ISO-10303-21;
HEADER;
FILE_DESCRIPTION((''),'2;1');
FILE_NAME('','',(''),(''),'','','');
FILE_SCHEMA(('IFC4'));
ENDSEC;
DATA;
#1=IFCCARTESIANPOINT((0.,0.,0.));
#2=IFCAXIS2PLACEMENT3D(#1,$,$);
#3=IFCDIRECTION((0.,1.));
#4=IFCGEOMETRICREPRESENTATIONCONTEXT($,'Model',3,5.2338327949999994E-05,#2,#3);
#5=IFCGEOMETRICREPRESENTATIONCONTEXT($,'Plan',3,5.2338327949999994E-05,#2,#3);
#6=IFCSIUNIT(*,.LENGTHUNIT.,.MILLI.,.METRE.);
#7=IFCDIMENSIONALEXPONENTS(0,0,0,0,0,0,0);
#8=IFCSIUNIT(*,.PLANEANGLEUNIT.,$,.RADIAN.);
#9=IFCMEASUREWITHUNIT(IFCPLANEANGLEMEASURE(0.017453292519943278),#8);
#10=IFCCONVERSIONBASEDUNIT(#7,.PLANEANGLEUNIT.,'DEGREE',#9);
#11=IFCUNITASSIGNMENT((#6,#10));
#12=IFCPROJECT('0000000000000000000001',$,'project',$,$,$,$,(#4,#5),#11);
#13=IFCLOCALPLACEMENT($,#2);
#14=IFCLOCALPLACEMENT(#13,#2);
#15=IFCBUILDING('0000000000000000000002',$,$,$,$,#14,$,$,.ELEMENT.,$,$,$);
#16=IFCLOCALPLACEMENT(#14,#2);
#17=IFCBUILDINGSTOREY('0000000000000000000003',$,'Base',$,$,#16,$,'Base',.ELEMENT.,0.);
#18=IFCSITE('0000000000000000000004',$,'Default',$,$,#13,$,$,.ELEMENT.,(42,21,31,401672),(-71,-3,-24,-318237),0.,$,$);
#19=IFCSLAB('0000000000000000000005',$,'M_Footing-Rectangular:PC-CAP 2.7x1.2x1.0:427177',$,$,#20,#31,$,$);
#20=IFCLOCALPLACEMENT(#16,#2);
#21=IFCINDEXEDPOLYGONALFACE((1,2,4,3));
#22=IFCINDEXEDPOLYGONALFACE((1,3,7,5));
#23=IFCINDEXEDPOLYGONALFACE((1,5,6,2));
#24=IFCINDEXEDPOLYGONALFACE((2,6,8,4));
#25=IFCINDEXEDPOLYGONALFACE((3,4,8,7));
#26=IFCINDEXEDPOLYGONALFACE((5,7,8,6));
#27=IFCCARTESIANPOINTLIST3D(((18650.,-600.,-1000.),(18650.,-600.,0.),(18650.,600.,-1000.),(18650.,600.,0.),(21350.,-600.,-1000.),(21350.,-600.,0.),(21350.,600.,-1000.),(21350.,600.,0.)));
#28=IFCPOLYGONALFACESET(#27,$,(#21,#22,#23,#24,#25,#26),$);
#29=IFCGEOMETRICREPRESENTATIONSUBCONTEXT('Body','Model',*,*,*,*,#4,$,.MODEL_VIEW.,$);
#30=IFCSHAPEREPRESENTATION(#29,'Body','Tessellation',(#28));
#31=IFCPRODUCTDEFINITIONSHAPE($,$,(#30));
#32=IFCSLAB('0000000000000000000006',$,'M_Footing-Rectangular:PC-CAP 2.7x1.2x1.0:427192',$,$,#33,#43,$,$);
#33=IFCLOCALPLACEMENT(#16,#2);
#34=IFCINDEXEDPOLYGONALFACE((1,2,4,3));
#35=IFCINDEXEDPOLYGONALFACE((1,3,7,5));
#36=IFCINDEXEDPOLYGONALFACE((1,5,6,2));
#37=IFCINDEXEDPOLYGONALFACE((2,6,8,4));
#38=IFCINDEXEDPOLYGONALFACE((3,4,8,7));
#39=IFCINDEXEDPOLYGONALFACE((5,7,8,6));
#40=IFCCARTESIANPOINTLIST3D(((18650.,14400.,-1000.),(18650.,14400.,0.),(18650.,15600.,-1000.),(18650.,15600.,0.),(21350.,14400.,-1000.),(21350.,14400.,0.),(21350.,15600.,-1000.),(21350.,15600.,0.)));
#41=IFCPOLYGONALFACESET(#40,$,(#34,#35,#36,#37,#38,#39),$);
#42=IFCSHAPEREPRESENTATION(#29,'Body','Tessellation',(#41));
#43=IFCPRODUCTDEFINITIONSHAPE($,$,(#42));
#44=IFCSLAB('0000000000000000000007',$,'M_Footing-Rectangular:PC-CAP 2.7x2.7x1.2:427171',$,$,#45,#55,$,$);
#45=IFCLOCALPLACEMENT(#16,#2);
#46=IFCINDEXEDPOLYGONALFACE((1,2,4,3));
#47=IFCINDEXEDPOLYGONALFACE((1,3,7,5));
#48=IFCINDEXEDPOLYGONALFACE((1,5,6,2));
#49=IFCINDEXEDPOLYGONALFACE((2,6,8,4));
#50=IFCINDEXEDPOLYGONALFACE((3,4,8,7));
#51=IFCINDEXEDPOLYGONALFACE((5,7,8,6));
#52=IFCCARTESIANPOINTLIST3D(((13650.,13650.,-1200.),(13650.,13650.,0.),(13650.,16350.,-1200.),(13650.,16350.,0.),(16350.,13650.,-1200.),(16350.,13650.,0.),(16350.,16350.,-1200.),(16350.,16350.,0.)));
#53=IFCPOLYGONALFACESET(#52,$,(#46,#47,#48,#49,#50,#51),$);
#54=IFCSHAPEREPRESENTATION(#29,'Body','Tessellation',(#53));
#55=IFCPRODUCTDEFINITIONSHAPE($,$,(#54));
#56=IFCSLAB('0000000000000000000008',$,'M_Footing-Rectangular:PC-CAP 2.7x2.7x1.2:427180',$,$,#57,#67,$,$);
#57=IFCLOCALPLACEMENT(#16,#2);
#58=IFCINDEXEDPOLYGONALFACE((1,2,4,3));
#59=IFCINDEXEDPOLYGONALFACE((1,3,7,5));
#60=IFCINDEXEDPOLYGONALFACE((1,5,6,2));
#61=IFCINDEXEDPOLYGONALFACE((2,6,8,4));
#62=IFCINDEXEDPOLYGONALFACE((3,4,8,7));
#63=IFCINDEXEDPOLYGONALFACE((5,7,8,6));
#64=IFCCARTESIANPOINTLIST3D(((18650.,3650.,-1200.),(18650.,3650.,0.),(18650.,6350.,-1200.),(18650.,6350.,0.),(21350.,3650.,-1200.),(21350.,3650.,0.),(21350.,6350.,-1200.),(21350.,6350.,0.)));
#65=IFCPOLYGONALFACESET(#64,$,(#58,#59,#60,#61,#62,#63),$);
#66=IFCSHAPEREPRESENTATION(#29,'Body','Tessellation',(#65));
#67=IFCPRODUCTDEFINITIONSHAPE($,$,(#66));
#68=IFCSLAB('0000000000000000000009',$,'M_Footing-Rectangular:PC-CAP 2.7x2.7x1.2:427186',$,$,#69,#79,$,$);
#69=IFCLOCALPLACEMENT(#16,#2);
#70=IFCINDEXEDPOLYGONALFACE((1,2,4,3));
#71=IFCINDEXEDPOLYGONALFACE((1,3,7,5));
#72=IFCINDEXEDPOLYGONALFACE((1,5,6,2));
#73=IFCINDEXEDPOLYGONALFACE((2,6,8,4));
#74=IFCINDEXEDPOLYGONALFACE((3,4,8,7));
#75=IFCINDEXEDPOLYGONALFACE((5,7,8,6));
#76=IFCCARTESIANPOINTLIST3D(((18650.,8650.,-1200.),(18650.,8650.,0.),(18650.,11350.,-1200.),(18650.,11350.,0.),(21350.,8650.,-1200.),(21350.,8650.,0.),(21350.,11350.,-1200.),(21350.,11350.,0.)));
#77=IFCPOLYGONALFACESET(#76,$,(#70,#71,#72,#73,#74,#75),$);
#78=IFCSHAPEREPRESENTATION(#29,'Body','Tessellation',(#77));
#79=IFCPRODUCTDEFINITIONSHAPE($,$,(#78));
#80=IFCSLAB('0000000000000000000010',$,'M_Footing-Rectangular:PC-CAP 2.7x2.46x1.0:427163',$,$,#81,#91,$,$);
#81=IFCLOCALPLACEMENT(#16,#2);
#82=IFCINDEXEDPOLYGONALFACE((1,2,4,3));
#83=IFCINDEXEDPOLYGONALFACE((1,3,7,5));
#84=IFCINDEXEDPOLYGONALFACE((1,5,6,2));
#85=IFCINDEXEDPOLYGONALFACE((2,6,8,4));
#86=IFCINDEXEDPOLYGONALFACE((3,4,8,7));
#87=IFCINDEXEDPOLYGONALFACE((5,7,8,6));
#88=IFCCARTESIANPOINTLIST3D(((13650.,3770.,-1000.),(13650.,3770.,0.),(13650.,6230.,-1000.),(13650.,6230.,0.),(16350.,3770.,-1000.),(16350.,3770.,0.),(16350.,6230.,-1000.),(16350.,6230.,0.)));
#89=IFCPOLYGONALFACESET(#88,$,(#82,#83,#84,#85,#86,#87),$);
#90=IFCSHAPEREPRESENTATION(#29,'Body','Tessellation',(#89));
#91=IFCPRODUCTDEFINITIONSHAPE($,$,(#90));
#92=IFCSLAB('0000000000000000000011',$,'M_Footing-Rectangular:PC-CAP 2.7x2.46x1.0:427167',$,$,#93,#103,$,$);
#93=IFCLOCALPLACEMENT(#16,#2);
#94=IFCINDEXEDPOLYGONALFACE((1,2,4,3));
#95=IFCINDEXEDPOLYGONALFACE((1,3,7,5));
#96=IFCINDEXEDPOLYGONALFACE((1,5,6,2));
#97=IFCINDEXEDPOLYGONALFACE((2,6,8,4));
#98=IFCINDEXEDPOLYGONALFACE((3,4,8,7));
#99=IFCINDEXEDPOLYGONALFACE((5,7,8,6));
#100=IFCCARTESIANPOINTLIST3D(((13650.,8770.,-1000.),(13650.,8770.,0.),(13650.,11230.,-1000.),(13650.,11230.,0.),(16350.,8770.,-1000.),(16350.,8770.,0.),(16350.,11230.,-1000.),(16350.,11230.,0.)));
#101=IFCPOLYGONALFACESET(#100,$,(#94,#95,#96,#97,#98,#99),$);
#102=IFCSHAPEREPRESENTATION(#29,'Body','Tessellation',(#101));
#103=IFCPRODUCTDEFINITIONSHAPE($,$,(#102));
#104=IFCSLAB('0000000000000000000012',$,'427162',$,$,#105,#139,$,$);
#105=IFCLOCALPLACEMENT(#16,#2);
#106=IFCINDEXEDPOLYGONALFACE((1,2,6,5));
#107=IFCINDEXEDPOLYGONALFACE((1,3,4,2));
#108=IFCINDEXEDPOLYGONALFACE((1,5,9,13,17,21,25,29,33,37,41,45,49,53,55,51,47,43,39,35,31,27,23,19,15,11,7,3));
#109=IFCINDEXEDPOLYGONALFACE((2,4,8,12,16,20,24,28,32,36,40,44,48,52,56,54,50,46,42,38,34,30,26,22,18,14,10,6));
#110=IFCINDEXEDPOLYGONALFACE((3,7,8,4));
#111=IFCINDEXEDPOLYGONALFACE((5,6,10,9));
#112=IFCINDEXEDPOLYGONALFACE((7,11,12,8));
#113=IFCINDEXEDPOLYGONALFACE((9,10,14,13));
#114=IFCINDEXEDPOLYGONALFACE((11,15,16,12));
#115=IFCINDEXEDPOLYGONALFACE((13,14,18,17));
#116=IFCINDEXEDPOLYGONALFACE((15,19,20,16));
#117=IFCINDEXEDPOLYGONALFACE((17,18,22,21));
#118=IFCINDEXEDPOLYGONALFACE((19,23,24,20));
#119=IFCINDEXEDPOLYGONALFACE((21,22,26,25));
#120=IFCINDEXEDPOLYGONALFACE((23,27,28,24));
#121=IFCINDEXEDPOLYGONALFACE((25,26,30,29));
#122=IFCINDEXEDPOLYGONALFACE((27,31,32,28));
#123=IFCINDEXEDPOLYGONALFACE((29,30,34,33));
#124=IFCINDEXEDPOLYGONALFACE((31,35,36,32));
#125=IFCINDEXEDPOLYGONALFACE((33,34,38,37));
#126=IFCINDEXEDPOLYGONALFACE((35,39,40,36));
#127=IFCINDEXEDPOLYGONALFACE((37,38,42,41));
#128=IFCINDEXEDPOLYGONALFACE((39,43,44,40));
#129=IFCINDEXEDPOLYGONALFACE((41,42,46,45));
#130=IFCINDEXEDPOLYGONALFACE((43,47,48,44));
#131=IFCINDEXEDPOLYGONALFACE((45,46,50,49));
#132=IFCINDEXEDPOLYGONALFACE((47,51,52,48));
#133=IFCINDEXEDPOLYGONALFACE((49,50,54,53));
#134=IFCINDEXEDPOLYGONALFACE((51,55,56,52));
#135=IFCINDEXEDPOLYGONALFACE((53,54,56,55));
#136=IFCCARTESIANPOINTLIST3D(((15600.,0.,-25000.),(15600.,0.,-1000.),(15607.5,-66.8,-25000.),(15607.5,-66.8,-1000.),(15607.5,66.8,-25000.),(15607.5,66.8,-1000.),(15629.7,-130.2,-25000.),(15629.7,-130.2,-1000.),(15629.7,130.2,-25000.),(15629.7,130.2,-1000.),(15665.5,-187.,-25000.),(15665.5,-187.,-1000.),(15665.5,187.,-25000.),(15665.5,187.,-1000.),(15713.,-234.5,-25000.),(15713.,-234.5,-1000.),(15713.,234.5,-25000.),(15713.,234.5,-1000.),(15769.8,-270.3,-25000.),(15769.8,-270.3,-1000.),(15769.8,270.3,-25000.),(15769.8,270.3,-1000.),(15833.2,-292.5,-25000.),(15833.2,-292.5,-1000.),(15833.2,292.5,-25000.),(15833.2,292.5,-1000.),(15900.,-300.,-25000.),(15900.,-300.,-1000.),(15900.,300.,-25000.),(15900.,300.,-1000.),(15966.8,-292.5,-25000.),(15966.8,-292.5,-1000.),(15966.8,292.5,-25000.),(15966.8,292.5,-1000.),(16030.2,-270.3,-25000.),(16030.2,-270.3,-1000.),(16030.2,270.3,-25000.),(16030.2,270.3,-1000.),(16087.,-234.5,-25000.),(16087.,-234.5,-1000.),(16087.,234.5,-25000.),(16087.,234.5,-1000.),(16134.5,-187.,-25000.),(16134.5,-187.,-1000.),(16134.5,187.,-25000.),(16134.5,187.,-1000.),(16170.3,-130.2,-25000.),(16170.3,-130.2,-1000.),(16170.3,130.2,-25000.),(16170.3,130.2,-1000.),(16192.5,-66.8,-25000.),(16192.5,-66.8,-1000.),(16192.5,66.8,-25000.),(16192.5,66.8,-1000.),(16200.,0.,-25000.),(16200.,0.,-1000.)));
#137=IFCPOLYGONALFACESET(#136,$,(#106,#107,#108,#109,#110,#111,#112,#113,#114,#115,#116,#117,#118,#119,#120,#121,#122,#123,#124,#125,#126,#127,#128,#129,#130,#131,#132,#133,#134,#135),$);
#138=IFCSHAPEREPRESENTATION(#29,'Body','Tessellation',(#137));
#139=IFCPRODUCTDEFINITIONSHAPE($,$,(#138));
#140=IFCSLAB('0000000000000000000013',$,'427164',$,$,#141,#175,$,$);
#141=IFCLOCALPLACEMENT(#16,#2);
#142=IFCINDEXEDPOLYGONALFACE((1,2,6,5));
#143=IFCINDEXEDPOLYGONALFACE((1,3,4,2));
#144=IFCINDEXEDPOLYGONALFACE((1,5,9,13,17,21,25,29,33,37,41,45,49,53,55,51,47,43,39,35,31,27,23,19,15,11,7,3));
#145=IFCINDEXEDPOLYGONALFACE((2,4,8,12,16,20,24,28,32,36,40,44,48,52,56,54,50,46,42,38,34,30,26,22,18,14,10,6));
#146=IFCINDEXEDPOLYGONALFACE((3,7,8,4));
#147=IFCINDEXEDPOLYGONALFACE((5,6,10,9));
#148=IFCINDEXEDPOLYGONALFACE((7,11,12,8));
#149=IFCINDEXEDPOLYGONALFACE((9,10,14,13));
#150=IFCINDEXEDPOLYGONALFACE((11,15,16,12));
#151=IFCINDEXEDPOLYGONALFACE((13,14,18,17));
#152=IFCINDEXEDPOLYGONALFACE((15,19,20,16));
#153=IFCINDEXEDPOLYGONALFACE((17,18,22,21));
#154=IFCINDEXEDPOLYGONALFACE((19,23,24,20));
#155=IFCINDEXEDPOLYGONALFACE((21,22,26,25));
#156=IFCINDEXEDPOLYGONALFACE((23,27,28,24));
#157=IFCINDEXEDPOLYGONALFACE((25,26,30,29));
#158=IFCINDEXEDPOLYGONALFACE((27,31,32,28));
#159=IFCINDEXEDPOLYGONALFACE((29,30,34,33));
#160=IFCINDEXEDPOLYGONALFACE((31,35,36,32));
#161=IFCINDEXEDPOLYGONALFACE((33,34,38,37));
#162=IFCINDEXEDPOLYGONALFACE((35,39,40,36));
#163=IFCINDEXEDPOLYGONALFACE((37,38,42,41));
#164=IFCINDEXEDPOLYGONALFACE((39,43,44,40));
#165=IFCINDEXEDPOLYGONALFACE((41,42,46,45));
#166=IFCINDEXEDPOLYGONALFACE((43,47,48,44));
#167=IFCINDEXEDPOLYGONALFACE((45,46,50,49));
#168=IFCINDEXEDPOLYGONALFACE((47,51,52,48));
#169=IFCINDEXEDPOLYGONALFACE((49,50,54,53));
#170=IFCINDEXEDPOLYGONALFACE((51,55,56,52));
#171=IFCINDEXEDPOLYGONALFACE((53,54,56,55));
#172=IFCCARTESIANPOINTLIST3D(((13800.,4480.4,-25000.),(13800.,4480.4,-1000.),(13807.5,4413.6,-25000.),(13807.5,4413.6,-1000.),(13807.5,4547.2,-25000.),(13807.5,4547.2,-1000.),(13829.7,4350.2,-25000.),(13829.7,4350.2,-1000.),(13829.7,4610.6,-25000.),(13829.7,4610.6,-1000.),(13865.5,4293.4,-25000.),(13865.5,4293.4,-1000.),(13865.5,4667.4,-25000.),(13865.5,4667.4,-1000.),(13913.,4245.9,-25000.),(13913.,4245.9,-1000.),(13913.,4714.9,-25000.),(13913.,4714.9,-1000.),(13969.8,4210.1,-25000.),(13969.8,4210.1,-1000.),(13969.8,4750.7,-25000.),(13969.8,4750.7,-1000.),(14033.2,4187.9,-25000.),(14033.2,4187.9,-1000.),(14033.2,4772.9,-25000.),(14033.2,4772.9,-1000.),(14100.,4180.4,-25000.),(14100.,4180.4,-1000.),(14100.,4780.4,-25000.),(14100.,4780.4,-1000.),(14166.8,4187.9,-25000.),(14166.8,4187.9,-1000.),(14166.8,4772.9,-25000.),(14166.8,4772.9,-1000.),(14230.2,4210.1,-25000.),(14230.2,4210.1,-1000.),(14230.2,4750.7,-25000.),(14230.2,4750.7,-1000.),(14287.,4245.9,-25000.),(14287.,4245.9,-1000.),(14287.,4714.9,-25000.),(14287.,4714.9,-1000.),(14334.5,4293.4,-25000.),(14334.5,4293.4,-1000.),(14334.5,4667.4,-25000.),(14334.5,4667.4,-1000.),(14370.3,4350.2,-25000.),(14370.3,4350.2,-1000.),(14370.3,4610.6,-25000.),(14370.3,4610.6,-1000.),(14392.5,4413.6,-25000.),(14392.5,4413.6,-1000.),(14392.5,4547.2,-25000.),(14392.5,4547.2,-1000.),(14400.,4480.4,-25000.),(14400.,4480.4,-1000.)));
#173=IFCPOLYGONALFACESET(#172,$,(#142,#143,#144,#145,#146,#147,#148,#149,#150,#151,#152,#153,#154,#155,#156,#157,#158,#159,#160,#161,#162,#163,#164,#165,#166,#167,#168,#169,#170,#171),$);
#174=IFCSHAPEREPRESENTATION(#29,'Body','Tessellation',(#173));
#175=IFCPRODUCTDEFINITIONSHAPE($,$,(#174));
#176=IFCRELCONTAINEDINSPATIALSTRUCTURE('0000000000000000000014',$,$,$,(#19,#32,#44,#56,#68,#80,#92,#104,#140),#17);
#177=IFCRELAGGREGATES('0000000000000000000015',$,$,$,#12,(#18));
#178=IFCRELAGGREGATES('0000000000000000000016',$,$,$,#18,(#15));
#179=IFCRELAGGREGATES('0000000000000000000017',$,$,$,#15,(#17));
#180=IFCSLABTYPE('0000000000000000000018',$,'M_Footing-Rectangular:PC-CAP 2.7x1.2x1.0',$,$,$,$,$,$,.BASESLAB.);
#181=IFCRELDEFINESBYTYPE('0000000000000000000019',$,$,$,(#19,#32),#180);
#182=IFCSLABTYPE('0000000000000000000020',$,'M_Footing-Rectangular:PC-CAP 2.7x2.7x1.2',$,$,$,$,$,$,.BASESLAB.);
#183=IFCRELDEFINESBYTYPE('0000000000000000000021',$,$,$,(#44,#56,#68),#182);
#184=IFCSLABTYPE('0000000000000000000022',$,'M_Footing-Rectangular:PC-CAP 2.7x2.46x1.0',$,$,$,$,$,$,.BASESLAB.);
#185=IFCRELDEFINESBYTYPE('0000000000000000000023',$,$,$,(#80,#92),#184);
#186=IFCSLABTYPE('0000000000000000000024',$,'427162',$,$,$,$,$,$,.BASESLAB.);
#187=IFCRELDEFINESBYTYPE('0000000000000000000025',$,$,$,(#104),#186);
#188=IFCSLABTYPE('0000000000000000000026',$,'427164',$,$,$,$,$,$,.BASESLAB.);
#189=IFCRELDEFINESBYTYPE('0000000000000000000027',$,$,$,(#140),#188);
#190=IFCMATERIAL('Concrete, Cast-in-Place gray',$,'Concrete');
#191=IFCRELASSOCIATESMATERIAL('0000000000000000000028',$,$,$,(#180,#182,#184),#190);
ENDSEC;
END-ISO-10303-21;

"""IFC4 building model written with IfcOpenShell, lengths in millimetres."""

from ifc_helpers import new_model, entity, si_unit, converted_unit, direction, frame, origin, place, context, subcontext, project, spatial, arc, indexed_curve, outline, extrude, material, type_object, element, save


model = new_model("IFC4")

# Units and contexts
model_context = context("Model", 3, precision=5.2338327949999994e-05, world=origin(), true_north=direction((0.0, 1.0)))
plan_context = context("Plan", 3, precision=5.2338327949999994e-05, world=origin(), true_north=direction((0.0, 1.0)))
body_context = subcontext(model_context, "Body", "Model", "MODEL_VIEW")
ifc_project = project(units=[si_unit("LENGTHUNIT", "METRE", prefix="MILLI"), converted_unit("PLANEANGLEUNIT", "DEGREE", entity("IfcPlaneAngleMeasure", 0.017453292519943278), si_unit("PLANEANGLEUNIT", "RADIAN"), dimensions=[0, 0, 0, 0, 0, 0, 0])], contexts=[model_context, plan_context])

# Site, building, storey
site_placement = place(None, origin())
site = spatial("IfcSite", under=ifc_project, at=site_placement, Name="Default", CompositionType="ELEMENT", RefLatitude=(42, 21, 31, 401672), RefLongitude=(-71, -3, -24, -318237), RefElevation=0.0)
building_placement = place(site_placement, origin())
building = spatial("IfcBuilding", under=site, at=building_placement, CompositionType="ELEMENT")
storey_placement = place(building_placement, origin())
storey = spatial("IfcBuildingStorey", under=building, at=storey_placement, Name="Base", LongName="Base", CompositionType="ELEMENT", Elevation=0.0)

# Slabs
ifc_material = material(Name="Concrete, Cast-in-Place gray", Category="Concrete")
slab_type_1 = type_object("IfcSlabType", Name="M_Footing-Rectangular:PC-CAP 2.7x1.2x1.0", PredefinedType="BASESLAB", material=ifc_material)
slab_1_placement = place(storey_placement, origin())
element("IfcSlab", 1, at=slab_1_placement, inside=storey, type_object=slab_type_1, Name="M_Footing-Rectangular:PC-CAP 2.7x1.2x1.0:427177", context=body_context, shape_type="SweptSolid", body=[
    extrude(outline(indexed_curve([(-1350.0, -600.0), (1350.0, -600.0), (1350.0, 600.0), (-1350.0, 600.0), (-1350.0, -600.0)], self_intersect=False)), frame((20000.0, 0.0, -1000.0), z_axis=(0.0, 0.0, 1.0), x_axis=(-1.0, 0.0, 0.0)), (0.0, 0.0, 1.0), 1000.0),
])
slab_2_placement = place(storey_placement, origin())
element("IfcSlab", 2, at=slab_2_placement, inside=storey, type_object=slab_type_1, Name="M_Footing-Rectangular:PC-CAP 2.7x1.2x1.0:427192", context=body_context, shape_type="SweptSolid", body=[
    extrude(outline(indexed_curve([(-1350.0, -600.0), (1350.0, -600.0), (1350.0, 600.0), (-1350.0, 600.0), (-1350.0, -600.0)], self_intersect=False)), frame((20000.0, 15000.0, -1000.0), z_axis=(0.0, 0.0, 1.0), x_axis=(-1.0, 0.0, 0.0)), (0.0, 0.0, 1.0), 1000.0),
])
slab_type_2 = type_object("IfcSlabType", Name="M_Footing-Rectangular:PC-CAP 2.7x2.7x1.2", PredefinedType="BASESLAB", material=ifc_material)
slab_3_placement = place(storey_placement, origin())
element("IfcSlab", 3, at=slab_3_placement, inside=storey, type_object=slab_type_2, Name="M_Footing-Rectangular:PC-CAP 2.7x2.7x1.2:427171", context=body_context, shape_type="SweptSolid", body=[
    extrude(outline(indexed_curve([(-1350.0, -1350.0), (1350.0, -1350.0), (1350.0, 1350.0), (-1350.0, 1350.0), (-1350.0, -1350.0)], self_intersect=False)), frame((15000.0, 15000.0, -1200.0), z_axis=(0.0, 0.0, 1.0), x_axis=(-1.0, 0.0, 0.0)), (0.0, 0.0, 1.0), 1200.0),
])
slab_4_placement = place(storey_placement, origin())
element("IfcSlab", 4, at=slab_4_placement, inside=storey, type_object=slab_type_2, Name="M_Footing-Rectangular:PC-CAP 2.7x2.7x1.2:427180", context=body_context, shape_type="SweptSolid", body=[
    extrude(outline(indexed_curve([(-1350.0, -1350.0), (1350.0, -1350.0), (1350.0, 1350.0), (-1350.0, 1350.0), (-1350.0, -1350.0)], self_intersect=False)), frame((20000.0, 5000.0, -1200.0), z_axis=(0.0, 0.0, 1.0), x_axis=(-1.0, 0.0, 0.0)), (0.0, 0.0, 1.0), 1200.0),
])
slab_5_placement = place(storey_placement, origin())
element("IfcSlab", 5, at=slab_5_placement, inside=storey, type_object=slab_type_2, Name="M_Footing-Rectangular:PC-CAP 2.7x2.7x1.2:427186", context=body_context, shape_type="SweptSolid", body=[
    extrude(outline(indexed_curve([(-1350.0, -1350.0), (1350.0, -1350.0), (1350.0, 1350.0), (-1350.0, 1350.0), (-1350.0, -1350.0)], self_intersect=False)), frame((20000.0, 10000.0, -1200.0), z_axis=(0.0, 0.0, 1.0), x_axis=(-1.0, 0.0, 0.0)), (0.0, 0.0, 1.0), 1200.0),
])
slab_type_3 = type_object("IfcSlabType", Name="M_Footing-Rectangular:PC-CAP 2.7x2.46x1.0", PredefinedType="BASESLAB", material=ifc_material)
slab_6_placement = place(storey_placement, origin())
element("IfcSlab", 6, at=slab_6_placement, inside=storey, type_object=slab_type_3, Name="M_Footing-Rectangular:PC-CAP 2.7x2.46x1.0:427163", context=body_context, shape_type="SweptSolid", body=[
    extrude(outline(indexed_curve([(-1350.0, -1230.0), (1350.0, -1230.0), (1350.0, 1230.0), (-1350.0, 1230.0), (-1350.0, -1230.0)], self_intersect=False)), frame((15000.0, 5000.0, -1000.0), z_axis=(0.0, 0.0, 1.0), x_axis=(-1.0, 0.0, 0.0)), (0.0, 0.0, 1.0), 1000.0),
])
slab_7_placement = place(storey_placement, origin())
element("IfcSlab", 7, at=slab_7_placement, inside=storey, type_object=slab_type_3, Name="M_Footing-Rectangular:PC-CAP 2.7x2.46x1.0:427167", context=body_context, shape_type="SweptSolid", body=[
    extrude(outline(indexed_curve([(-1350.0, -1230.0), (1350.0, -1230.0), (1350.0, 1230.0), (-1350.0, 1230.0), (-1350.0, -1230.0)], self_intersect=False)), frame((15000.0, 10000.0, -1000.0), z_axis=(0.0, 0.0, 1.0), x_axis=(-1.0, 0.0, 0.0)), (0.0, 0.0, 1.0), 1000.0),
])
slab_type_4 = type_object("IfcSlabType", Name="427162", PredefinedType="BASESLAB")
slab_8_placement = place(storey_placement, origin())
element("IfcSlab", 8, at=slab_8_placement, inside=storey, type_object=slab_type_4, Name="427162", context=body_context, shape_type="SweptSolid", body=[
    extrude(outline(indexed_curve([(300.0, 0.0), (0.0, 300.0), (-300.0, 0.0), (0.0, -300.0)], segments=[arc(1, 2, 3), arc(3, 4, 1)], self_intersect=False)), frame((15900.0, 0.0, -25000.0)), (0.0, 0.0, 1.0), 24000.0),
])
slab_type_5 = type_object("IfcSlabType", Name="427164", PredefinedType="BASESLAB")
slab_9_placement = place(storey_placement, origin())
element("IfcSlab", 9, at=slab_9_placement, inside=storey, type_object=slab_type_5, Name="427164", context=body_context, shape_type="SweptSolid", body=[
    extrude(outline(indexed_curve([(300.0, 0.0), (0.0, 300.0), (-300.0, 0.0), (0.0, -300.0)], segments=[arc(1, 2, 3), arc(3, 4, 1)], self_intersect=False)), frame((14100.0, 4480.4, -25000.0)), (0.0, 0.0, 1.0), 24000.0),
])

save(model, "model.ifc")
